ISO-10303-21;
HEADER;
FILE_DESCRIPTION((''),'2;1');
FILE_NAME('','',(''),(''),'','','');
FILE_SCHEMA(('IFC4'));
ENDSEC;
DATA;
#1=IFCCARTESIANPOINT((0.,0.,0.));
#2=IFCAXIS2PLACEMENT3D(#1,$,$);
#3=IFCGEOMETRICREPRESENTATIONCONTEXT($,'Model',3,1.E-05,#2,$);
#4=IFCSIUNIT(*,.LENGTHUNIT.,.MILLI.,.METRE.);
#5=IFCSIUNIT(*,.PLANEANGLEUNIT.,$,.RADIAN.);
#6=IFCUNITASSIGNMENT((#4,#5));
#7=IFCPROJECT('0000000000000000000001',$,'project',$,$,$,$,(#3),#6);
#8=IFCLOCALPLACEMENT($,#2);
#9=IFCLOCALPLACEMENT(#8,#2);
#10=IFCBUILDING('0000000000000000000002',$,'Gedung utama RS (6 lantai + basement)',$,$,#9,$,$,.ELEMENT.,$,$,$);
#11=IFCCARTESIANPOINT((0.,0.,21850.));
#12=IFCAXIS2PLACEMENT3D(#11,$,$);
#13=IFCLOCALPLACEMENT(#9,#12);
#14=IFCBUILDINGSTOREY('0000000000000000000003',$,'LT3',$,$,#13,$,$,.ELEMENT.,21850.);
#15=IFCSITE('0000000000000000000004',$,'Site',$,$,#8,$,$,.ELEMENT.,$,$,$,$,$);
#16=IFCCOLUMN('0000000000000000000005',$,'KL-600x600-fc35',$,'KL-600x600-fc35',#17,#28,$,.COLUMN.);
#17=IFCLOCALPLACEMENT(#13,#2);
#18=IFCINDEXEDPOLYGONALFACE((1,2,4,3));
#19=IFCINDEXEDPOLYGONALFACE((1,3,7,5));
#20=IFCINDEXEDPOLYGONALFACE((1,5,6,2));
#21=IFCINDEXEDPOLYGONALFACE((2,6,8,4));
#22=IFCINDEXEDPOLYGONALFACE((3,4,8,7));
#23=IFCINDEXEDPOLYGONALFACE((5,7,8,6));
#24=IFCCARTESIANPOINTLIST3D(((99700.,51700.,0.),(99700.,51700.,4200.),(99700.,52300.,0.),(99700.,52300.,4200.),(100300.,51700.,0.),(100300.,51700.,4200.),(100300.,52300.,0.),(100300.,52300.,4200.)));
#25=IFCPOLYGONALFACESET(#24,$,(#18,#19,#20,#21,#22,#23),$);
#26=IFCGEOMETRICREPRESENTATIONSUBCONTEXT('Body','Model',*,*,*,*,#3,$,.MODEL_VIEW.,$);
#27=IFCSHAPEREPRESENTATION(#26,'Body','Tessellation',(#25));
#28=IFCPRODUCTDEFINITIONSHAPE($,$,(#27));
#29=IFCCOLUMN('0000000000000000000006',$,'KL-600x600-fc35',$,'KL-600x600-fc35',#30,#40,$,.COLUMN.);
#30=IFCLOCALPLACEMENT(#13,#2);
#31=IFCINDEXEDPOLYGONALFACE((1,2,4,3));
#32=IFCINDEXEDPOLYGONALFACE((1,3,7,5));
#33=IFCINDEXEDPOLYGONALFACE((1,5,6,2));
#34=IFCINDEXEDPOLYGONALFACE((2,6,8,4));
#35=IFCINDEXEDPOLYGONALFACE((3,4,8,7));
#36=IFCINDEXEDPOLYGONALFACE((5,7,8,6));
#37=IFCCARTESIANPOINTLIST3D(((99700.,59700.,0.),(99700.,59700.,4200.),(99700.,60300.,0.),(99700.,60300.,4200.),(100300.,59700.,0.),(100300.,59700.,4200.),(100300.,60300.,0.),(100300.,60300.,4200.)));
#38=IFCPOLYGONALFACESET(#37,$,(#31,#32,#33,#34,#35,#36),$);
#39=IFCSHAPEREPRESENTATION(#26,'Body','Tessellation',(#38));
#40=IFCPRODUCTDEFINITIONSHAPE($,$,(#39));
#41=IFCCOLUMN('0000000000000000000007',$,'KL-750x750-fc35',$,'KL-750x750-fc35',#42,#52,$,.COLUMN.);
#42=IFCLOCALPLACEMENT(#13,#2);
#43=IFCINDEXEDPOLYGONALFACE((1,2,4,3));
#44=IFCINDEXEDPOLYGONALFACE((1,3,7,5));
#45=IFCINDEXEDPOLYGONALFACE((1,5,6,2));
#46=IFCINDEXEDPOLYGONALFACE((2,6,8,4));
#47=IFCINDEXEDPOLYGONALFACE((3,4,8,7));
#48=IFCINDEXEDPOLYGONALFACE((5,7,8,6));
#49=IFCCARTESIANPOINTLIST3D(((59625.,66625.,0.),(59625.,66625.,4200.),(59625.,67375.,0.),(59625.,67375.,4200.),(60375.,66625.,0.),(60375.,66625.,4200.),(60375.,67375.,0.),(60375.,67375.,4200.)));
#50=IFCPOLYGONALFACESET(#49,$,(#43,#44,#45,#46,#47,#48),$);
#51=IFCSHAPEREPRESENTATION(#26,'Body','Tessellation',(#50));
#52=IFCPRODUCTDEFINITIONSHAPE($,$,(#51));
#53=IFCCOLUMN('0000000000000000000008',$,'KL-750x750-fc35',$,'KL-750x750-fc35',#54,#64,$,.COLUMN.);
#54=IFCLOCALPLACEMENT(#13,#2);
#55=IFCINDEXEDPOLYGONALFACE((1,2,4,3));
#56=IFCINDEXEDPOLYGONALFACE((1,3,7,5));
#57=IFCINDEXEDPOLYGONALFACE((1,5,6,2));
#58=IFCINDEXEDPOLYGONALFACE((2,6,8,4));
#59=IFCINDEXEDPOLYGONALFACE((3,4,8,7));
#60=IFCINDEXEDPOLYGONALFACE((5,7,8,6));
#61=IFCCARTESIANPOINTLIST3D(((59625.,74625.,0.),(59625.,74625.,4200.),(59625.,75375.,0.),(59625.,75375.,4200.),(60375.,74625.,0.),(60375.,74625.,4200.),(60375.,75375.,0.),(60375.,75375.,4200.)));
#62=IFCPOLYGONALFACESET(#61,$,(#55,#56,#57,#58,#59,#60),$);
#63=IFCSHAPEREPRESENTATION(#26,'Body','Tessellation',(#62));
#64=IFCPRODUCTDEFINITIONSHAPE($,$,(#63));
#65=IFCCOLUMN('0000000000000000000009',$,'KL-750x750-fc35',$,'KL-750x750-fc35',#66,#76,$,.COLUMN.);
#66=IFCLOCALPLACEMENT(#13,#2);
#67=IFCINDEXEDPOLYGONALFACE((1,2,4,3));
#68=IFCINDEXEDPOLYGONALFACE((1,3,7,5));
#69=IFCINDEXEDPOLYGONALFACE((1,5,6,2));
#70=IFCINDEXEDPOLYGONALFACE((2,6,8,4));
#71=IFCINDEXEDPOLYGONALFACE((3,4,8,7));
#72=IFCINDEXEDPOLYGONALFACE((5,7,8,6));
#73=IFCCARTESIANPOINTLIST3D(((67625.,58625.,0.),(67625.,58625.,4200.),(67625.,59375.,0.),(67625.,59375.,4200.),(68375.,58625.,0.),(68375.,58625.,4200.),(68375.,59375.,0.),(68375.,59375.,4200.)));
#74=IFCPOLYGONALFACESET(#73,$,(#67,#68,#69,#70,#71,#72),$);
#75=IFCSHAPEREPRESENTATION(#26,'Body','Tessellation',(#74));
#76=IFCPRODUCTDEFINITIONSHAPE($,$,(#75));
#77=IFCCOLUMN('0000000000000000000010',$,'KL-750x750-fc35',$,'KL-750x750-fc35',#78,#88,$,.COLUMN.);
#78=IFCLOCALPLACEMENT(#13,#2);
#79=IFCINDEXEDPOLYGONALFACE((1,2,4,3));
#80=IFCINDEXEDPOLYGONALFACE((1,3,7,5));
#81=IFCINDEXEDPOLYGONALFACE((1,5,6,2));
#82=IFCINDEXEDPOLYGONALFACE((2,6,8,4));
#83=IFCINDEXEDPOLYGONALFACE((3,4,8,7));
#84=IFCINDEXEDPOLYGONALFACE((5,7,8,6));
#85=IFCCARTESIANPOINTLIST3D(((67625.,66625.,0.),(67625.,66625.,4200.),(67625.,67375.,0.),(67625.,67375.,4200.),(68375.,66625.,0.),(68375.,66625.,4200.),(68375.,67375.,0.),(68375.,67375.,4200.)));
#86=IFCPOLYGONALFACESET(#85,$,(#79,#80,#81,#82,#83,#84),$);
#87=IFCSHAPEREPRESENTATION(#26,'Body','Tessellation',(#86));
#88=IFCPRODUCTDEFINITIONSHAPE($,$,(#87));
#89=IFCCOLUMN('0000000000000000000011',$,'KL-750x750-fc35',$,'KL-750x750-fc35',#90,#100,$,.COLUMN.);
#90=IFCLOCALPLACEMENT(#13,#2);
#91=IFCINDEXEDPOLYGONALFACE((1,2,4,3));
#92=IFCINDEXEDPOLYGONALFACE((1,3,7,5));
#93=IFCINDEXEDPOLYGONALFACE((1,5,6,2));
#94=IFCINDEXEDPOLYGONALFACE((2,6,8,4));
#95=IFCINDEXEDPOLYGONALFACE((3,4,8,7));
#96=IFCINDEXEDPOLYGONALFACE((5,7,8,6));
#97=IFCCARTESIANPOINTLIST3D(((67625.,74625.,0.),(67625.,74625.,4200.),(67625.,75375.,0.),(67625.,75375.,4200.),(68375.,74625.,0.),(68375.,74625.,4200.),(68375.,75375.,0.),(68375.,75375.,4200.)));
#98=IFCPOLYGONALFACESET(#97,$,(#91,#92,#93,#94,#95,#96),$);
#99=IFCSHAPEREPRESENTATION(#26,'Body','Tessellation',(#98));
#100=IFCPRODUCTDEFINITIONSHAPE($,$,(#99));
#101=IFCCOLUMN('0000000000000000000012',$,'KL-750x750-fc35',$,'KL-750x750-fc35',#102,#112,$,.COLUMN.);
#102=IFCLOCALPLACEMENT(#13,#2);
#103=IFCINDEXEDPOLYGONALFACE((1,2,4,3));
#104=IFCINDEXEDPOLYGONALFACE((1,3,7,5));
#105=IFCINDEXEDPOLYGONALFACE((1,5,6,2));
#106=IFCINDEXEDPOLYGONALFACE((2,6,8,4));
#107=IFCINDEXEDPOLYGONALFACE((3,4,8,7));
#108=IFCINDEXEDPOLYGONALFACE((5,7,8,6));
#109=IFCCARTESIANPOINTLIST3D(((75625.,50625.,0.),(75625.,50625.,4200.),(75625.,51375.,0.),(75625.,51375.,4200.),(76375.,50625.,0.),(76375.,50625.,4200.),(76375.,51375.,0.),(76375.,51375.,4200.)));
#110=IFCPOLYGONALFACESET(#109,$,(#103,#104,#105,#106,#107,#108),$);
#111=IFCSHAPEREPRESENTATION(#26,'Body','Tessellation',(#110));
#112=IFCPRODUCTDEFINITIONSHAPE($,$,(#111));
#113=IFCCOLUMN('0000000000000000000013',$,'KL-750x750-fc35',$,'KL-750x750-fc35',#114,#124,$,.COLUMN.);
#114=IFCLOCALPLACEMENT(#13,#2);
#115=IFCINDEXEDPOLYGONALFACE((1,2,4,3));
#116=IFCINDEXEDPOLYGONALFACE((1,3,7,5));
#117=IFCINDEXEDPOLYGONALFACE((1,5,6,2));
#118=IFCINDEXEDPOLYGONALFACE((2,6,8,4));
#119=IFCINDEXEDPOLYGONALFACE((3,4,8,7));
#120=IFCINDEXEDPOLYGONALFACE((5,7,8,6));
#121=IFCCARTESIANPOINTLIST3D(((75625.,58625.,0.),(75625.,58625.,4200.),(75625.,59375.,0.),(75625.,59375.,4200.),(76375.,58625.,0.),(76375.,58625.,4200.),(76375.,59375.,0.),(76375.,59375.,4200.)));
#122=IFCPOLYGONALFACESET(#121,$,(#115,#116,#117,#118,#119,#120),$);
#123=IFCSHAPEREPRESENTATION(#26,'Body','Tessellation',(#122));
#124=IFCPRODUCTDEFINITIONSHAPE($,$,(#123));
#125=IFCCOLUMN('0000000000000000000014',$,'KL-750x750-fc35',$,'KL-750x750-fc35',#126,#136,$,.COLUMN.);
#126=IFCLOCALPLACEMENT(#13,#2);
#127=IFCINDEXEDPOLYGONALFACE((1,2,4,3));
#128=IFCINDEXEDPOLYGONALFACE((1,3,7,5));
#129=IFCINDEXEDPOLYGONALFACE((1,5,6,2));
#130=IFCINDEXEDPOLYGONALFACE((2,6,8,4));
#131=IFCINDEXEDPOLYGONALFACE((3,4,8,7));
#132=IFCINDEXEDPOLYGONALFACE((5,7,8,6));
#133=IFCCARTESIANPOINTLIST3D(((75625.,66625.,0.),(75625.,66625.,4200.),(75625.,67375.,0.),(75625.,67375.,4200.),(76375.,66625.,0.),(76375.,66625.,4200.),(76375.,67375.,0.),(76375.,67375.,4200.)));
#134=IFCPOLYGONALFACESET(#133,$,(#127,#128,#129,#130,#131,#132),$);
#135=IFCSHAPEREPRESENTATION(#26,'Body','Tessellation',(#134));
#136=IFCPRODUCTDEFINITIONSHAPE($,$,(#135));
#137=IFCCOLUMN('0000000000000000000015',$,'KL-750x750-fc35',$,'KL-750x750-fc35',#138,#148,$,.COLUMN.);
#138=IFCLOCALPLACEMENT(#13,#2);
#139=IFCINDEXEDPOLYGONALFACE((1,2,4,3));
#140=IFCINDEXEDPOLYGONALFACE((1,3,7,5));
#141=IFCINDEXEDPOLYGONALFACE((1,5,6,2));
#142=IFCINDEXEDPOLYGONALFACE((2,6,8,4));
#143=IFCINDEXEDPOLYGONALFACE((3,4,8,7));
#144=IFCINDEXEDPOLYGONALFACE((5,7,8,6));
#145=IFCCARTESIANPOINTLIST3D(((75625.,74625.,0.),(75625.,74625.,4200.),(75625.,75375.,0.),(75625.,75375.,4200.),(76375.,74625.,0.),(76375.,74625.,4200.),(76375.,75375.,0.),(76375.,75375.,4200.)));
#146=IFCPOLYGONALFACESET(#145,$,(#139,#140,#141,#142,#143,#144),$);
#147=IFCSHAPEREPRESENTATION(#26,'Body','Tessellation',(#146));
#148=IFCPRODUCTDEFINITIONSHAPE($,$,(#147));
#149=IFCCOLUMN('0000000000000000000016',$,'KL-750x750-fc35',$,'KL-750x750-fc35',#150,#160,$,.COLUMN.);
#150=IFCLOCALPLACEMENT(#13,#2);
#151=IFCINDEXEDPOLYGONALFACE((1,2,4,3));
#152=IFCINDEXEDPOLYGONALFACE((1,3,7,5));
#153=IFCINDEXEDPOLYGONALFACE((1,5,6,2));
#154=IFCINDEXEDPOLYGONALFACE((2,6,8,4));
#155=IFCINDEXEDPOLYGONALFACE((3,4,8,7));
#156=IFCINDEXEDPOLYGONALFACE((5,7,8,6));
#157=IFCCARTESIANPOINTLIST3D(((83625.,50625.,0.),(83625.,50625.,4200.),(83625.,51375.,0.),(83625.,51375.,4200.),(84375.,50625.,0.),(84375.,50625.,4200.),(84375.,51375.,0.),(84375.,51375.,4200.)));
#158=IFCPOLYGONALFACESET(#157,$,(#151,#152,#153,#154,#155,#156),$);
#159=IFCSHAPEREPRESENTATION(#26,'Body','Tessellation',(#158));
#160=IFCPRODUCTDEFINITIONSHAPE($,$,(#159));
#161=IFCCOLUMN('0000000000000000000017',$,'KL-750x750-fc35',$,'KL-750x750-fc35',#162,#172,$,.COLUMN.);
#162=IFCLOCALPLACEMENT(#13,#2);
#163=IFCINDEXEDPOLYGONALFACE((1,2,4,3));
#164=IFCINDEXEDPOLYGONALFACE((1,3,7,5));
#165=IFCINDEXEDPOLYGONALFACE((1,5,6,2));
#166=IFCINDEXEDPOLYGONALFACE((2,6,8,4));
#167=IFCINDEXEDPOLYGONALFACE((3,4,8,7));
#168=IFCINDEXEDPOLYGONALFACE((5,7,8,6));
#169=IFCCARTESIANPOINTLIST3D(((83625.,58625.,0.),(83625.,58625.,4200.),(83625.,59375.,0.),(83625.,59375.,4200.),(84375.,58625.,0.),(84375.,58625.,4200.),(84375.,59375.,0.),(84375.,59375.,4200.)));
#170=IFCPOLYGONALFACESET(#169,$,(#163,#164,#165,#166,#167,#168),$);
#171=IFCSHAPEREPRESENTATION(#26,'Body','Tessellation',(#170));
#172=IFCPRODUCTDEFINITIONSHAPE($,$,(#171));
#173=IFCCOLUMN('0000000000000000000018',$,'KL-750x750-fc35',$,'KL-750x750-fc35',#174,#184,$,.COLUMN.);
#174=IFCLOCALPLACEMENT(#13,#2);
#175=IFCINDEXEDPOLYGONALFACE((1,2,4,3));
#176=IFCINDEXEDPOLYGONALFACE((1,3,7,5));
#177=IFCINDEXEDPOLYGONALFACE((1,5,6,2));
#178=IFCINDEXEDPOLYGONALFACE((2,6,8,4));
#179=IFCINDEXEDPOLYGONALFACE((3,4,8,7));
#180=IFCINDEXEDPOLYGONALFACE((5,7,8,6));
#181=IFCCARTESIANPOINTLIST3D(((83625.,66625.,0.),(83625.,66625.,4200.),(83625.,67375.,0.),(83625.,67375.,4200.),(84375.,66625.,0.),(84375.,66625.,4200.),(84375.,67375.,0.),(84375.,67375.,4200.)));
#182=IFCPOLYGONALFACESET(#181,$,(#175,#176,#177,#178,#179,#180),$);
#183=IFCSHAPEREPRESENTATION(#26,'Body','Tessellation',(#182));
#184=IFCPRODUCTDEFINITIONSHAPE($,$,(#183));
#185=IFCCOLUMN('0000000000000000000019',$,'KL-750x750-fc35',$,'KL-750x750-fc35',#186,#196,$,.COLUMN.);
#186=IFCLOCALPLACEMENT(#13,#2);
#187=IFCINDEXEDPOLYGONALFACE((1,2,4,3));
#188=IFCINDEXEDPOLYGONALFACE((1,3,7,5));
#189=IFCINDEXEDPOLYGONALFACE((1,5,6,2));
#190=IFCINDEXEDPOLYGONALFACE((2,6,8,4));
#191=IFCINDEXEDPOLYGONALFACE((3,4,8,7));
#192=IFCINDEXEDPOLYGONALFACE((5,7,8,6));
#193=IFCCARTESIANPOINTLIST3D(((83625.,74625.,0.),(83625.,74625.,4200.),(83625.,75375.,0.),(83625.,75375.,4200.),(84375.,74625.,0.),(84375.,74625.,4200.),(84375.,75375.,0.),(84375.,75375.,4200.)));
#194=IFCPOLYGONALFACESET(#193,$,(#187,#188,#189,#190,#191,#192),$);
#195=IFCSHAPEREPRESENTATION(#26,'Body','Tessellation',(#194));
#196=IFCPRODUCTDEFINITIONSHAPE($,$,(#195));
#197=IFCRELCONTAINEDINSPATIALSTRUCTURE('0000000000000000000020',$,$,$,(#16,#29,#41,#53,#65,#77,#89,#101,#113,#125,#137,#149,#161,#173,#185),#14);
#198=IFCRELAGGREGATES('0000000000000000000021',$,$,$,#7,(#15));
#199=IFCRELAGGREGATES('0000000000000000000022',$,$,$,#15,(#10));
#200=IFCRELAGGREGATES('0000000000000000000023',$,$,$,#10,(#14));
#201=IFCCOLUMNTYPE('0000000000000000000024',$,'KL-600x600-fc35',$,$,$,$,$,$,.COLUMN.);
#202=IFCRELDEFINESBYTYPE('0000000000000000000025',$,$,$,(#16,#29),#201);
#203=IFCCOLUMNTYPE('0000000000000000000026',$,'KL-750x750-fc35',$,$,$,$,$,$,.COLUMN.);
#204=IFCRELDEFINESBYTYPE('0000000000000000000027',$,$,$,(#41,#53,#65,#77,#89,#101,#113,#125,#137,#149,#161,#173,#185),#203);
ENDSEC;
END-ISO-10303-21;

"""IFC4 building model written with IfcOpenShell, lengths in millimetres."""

from ifc_helpers import new_model, si_unit, frame, origin, origin_2d, place, context, subcontext, project, spatial, rectangle, extrude, material_profile, profile_set, profile_usage, type_object, element, save


model = new_model("IFC4")

# Units and contexts
model_context = context("Model", 3, precision=1e-05, world=origin())
body_context = subcontext(model_context, "Body", "Model", "MODEL_VIEW")
ifc_project = project(units=[si_unit("LENGTHUNIT", "METRE", prefix="MILLI"), si_unit("PLANEANGLEUNIT", "RADIAN")], contexts=[model_context])

# Site, building, storey
site_placement = place(None, origin())
site = spatial("IfcSite", under=ifc_project, at=site_placement, Name="Site", CompositionType="ELEMENT")
building_placement = place(site_placement, origin())
building = spatial("IfcBuilding", under=site, at=building_placement, Name="Gedung utama RS (6 lantai + basement)", CompositionType="ELEMENT")
storey_placement = place(building_placement, frame((0.0, 0.0, 21850.0)))
storey = spatial("IfcBuildingStorey", under=building, at=storey_placement, Name="LT3", CompositionType="ELEMENT", Elevation=21850.0)

# Columns
ifc_material_profile_1 = material_profile(None, rectangle(XDim=600.0, YDim=600.0, at=origin_2d()), Name="KL-600x600-fc35")
ifc_profile_set_1 = profile_set([ifc_material_profile_1], Name="KL-600x600-fc35")
ifc_profile_usage_1 = profile_usage(ifc_profile_set_1, cardinal=5)
column_type_1 = type_object("IfcColumnType", Name="KL-600x600-fc35", PredefinedType="COLUMN", material=ifc_profile_set_1)
for number, where, z_axis, x_axis, name in (
    (1, (100000.0, 52000.0, 0.0), (0.0, 0.0, 1.0), (1.0, 0.0, 0.0), "KL-600x600-fc35"),
    (2, (100000.0, 60000.0, 0.0), (0.0, 0.0, 1.0), (1.0, 0.0, 0.0), "KL-600x600-fc35"),
):
    element("IfcColumn", number, at=place(storey_placement, frame(where, z_axis=z_axis, x_axis=x_axis)), inside=storey, type_object=column_type_1, material=ifc_profile_usage_1, Name=name, ObjectType="KL-600x600-fc35", PredefinedType="COLUMN", context=body_context, shape_type="SweptSolid", body=[
        extrude(rectangle(XDim=600.0, YDim=600.0, at=origin_2d()), origin(), (0.0, 0.0, 1.0), 4200.0),
    ])
ifc_material_profile_2 = material_profile(None, rectangle(XDim=750.0, YDim=750.0, at=origin_2d()), Name="KL-750x750-fc35")
ifc_profile_set_2 = profile_set([ifc_material_profile_2], Name="KL-750x750-fc35")
ifc_profile_usage_2 = profile_usage(ifc_profile_set_2, cardinal=5)
column_type_2 = type_object("IfcColumnType", Name="KL-750x750-fc35", PredefinedType="COLUMN", material=ifc_profile_set_2)
for number, where, z_axis, x_axis, name in (
    (3, (60000.0, 67000.0, 0.0), (0.0, 0.0, 1.0), (1.0, 0.0, 0.0), "KL-750x750-fc35"),
    (4, (60000.0, 75000.0, 0.0), (0.0, 0.0, 1.0), (1.0, 0.0, 0.0), "KL-750x750-fc35"),
    (5, (68000.0, 59000.0, 0.0), (0.0, 0.0, 1.0), (1.0, 0.0, 0.0), "KL-750x750-fc35"),
    (6, (68000.0, 67000.0, 0.0), (0.0, 0.0, 1.0), (1.0, 0.0, 0.0), "KL-750x750-fc35"),
    (7, (68000.0, 75000.0, 0.0), (0.0, 0.0, 1.0), (1.0, 0.0, 0.0), "KL-750x750-fc35"),
    (8, (76000.0, 51000.0, 0.0), (0.0, 0.0, 1.0), (1.0, 0.0, 0.0), "KL-750x750-fc35"),
    (9, (76000.0, 59000.0, 0.0), (0.0, 0.0, 1.0), (1.0, 0.0, 0.0), "KL-750x750-fc35"),
    (10, (76000.0, 67000.0, 0.0), (0.0, 0.0, 1.0), (1.0, 0.0, 0.0), "KL-750x750-fc35"),
    (11, (76000.0, 75000.0, 0.0), (0.0, 0.0, 1.0), (1.0, 0.0, 0.0), "KL-750x750-fc35"),
    (12, (84000.0, 51000.0, 0.0), (0.0, 0.0, 1.0), (1.0, 0.0, 0.0), "KL-750x750-fc35"),
    (13, (84000.0, 59000.0, 0.0), (0.0, 0.0, 1.0), (1.0, 0.0, 0.0), "KL-750x750-fc35"),
    (14, (84000.0, 67000.0, 0.0), (0.0, 0.0, 1.0), (1.0, 0.0, 0.0), "KL-750x750-fc35"),
    (15, (84000.0, 75000.0, 0.0), (0.0, 0.0, 1.0), (1.0, 0.0, 0.0), "KL-750x750-fc35"),
):
    element("IfcColumn", number, at=place(storey_placement, frame(where, z_axis=z_axis, x_axis=x_axis)), inside=storey, type_object=column_type_2, material=ifc_profile_usage_2, Name=name, ObjectType="KL-750x750-fc35", PredefinedType="COLUMN", context=body_context, shape_type="SweptSolid", body=[
        extrude(rectangle(XDim=750.0, YDim=750.0, at=origin_2d()), origin(), (0.0, 0.0, 1.0), 4200.0),
    ])

save(model, "model.ifc")
